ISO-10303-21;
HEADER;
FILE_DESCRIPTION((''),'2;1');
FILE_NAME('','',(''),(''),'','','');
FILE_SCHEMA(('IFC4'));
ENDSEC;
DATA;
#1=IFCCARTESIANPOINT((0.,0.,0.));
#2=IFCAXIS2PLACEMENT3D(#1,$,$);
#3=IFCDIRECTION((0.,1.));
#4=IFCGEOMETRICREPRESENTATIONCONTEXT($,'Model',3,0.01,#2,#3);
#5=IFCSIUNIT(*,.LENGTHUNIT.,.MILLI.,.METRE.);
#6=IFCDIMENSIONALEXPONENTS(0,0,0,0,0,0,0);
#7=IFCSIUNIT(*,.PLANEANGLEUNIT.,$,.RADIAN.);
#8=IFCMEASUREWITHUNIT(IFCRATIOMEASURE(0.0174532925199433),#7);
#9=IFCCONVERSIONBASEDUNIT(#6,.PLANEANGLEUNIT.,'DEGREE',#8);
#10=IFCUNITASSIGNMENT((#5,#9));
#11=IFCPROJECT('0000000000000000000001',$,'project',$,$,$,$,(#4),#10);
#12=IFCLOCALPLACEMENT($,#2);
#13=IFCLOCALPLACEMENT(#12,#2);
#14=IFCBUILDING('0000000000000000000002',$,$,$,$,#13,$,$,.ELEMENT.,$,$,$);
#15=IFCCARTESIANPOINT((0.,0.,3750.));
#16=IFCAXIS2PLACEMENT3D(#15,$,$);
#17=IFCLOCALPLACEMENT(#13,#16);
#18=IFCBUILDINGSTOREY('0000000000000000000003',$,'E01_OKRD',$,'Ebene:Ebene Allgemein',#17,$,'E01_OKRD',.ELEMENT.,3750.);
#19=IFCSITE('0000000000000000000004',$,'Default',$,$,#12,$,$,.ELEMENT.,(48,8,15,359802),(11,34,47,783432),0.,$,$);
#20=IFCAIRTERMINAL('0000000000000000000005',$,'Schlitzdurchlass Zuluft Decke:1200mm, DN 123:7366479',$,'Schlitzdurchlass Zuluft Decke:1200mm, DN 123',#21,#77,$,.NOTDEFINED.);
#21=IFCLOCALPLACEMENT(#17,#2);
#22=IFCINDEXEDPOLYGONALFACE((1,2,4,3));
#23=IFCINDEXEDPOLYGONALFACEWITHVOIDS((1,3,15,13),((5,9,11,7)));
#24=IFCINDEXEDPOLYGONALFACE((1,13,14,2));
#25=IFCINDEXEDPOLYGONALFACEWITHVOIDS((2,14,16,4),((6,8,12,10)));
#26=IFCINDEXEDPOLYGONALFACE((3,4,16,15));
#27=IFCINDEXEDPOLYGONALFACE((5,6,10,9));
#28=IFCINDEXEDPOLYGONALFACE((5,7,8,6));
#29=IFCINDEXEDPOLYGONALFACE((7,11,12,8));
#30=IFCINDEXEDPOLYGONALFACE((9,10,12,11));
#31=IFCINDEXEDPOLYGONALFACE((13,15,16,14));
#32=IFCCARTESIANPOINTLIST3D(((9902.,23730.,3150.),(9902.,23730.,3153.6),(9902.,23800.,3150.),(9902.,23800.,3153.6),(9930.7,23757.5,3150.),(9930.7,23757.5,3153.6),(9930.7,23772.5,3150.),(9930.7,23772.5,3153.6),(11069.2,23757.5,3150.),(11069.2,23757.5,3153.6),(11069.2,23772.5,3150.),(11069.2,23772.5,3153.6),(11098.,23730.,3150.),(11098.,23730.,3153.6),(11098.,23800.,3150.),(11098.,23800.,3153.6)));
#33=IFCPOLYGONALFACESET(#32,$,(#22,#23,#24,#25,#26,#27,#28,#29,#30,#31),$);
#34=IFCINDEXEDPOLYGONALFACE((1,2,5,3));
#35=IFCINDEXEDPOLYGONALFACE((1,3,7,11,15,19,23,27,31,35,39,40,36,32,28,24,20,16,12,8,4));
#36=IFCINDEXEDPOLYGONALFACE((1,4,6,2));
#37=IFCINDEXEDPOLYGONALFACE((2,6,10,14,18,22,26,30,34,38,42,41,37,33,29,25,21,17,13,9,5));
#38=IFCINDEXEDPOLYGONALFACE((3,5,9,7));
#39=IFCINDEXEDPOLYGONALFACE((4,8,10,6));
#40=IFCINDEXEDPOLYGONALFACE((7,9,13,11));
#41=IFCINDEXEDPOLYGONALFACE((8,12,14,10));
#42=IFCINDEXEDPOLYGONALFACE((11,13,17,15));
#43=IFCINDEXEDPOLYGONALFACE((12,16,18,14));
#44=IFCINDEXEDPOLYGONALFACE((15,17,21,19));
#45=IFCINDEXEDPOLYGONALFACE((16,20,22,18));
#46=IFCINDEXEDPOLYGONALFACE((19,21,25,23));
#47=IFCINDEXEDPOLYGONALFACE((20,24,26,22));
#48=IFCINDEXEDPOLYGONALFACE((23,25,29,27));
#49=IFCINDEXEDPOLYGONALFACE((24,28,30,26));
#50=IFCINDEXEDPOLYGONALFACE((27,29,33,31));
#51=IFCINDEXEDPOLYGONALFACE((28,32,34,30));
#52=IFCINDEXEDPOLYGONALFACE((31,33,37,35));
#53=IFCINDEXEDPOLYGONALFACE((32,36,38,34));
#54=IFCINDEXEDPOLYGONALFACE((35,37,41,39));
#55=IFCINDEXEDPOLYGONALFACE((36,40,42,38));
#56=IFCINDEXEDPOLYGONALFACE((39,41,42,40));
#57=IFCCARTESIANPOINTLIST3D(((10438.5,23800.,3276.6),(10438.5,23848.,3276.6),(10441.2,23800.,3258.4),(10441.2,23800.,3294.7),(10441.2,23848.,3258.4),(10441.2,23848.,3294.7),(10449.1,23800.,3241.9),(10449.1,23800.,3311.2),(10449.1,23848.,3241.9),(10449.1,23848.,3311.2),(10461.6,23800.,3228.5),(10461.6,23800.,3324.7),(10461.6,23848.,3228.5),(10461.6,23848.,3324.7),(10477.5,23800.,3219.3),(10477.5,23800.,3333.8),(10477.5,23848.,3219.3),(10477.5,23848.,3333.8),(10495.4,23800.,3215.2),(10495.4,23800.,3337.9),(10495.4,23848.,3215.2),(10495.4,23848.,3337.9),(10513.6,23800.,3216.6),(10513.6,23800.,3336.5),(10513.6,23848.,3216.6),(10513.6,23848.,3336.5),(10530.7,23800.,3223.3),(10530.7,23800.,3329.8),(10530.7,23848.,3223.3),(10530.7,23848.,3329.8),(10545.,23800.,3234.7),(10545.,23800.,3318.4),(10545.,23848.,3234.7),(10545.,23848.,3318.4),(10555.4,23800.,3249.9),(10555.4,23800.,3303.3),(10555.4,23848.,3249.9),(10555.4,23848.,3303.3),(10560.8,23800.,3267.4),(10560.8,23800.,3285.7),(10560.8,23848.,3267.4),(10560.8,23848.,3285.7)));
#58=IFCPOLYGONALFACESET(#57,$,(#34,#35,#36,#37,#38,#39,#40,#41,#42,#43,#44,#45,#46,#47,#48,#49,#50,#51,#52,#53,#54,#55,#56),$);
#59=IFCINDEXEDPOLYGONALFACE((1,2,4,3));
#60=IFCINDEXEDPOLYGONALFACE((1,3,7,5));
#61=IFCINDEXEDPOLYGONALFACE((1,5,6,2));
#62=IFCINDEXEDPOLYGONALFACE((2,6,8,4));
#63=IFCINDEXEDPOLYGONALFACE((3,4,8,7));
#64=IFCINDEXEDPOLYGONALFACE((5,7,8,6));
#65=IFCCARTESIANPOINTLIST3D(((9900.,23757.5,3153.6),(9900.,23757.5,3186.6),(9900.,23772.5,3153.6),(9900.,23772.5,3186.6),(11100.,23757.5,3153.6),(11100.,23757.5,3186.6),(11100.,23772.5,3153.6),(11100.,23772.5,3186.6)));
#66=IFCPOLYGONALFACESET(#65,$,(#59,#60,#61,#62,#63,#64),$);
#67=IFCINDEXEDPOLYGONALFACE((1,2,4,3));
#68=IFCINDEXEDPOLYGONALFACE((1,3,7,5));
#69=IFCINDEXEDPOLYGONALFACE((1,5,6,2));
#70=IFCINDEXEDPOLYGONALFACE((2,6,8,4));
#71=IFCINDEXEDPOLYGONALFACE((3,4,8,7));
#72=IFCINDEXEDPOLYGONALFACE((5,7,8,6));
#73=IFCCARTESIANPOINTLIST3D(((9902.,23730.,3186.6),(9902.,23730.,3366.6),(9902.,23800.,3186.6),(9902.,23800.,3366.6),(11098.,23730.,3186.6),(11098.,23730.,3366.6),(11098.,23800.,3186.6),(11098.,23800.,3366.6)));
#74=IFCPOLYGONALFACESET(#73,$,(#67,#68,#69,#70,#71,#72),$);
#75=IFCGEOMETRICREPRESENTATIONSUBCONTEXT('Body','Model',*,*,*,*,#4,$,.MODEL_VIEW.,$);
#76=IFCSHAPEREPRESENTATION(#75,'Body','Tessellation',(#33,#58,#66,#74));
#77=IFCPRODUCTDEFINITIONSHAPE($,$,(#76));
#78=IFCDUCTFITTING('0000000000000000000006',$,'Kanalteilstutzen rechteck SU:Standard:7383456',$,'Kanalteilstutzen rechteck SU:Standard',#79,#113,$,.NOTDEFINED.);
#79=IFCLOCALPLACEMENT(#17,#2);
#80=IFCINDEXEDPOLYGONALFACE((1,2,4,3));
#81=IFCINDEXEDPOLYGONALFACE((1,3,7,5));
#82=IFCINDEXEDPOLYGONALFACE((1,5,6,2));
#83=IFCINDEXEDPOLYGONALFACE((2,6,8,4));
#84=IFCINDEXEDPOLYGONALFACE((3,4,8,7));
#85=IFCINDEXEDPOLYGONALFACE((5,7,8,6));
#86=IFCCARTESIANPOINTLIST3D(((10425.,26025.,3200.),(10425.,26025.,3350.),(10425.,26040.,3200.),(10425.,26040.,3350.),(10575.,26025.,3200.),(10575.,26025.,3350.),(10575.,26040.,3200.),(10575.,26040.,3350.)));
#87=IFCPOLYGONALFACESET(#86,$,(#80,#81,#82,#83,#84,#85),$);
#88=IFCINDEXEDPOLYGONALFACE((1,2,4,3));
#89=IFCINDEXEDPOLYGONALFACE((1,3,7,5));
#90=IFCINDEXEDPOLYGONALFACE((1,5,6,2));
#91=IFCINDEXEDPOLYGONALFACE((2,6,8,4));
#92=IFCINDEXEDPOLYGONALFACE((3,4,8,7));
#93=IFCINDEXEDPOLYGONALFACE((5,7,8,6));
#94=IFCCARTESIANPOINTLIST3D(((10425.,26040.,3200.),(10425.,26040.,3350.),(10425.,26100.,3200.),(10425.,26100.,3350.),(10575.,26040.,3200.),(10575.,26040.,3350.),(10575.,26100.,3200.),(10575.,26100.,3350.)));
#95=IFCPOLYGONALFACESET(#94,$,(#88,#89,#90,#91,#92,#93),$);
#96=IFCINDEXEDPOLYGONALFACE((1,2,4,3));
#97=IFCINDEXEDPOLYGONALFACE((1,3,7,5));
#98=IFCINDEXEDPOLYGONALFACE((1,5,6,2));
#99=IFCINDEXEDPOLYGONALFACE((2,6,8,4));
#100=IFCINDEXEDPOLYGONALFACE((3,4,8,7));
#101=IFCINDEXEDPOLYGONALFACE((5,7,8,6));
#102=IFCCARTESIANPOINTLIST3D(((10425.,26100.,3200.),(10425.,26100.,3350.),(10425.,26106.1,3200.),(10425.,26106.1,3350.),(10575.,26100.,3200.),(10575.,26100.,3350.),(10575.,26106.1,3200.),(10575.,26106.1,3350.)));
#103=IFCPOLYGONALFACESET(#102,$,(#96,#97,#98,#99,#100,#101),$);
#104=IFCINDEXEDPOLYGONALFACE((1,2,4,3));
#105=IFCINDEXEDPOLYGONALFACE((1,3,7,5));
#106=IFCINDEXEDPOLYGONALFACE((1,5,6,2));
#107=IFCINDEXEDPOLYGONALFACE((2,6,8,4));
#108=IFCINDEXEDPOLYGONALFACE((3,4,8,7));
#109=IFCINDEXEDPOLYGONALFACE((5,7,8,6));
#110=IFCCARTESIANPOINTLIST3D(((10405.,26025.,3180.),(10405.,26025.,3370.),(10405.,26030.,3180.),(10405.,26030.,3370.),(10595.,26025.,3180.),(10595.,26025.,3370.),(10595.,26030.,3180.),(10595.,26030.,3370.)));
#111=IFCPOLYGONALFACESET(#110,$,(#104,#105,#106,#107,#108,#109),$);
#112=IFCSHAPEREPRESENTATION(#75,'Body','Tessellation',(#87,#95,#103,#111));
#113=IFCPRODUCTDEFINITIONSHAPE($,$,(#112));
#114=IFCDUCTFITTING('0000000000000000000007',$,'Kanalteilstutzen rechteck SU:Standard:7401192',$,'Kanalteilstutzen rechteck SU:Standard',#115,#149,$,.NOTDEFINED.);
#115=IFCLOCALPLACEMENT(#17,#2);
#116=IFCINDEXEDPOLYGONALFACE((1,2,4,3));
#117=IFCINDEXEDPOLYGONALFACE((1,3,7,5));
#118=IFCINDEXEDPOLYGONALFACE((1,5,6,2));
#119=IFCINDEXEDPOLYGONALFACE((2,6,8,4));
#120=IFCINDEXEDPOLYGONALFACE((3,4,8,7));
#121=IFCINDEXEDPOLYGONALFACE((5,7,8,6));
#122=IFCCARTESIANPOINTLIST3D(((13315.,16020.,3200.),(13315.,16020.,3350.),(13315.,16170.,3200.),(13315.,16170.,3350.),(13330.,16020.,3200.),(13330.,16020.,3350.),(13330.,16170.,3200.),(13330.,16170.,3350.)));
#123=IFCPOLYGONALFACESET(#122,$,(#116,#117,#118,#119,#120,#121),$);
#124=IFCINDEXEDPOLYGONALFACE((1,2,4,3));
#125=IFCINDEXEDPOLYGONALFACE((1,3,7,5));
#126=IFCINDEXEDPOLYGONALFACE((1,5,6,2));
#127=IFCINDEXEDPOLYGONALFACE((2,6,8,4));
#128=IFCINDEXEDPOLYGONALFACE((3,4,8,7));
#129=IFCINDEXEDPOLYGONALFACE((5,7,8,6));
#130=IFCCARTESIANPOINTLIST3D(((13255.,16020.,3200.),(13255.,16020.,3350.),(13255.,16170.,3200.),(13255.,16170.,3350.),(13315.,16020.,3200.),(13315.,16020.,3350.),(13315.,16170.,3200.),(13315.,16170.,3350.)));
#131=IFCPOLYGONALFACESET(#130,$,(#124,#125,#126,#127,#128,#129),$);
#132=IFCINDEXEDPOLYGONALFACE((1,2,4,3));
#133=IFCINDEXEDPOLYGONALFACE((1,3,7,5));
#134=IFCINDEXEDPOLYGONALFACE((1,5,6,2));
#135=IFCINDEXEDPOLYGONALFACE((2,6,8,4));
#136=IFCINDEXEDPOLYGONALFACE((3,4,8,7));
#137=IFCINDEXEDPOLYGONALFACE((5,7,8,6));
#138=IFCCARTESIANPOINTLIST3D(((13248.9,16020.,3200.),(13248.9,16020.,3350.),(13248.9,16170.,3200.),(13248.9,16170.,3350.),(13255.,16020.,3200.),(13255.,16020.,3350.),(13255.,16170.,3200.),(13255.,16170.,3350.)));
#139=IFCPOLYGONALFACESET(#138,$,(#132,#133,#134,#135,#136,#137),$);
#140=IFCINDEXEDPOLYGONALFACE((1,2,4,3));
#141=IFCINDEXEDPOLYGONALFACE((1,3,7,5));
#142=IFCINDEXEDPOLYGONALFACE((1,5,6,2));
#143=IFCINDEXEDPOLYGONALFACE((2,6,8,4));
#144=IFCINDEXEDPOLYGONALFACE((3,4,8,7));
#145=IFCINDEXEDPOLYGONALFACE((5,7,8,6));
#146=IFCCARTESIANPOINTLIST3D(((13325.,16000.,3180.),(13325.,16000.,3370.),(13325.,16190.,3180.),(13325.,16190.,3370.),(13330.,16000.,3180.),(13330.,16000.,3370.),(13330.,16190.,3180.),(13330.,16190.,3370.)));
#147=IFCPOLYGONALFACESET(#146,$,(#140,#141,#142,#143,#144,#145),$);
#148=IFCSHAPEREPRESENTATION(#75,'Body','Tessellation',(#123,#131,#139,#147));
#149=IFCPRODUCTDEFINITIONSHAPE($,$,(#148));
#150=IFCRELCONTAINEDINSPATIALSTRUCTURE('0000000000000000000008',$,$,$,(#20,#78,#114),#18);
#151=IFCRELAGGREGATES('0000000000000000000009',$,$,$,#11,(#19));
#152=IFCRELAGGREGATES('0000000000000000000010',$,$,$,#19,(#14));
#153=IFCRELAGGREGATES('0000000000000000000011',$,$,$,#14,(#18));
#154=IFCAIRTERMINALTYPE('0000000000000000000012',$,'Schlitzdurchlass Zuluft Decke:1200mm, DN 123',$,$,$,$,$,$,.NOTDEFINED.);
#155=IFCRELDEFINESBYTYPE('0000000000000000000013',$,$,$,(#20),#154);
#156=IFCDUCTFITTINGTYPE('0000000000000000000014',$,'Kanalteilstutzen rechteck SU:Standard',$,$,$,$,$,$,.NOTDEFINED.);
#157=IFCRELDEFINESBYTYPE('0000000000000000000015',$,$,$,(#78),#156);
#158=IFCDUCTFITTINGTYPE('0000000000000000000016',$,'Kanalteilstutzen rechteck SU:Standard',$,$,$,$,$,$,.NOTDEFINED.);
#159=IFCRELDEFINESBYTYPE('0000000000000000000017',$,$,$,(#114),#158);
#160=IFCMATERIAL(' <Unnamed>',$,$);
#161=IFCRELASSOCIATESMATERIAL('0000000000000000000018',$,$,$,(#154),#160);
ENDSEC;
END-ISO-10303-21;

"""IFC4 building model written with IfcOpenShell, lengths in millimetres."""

from ifc_helpers import new_model, entity, si_unit, converted_unit, direction, frame, frame_2d, origin, origin_2d_with_axis, place, context, subcontext, project, spatial, polyline, rectangle, circle, outline, extrude, source, transform, mapped, material, type_object, type_shapes, element, save


model = new_model("IFC4")

# Units and contexts
model_context = context("Model", 3, precision=0.01, world=origin(), true_north=direction((0.0, 1.0)))
body_context = subcontext(model_context, "Body", "Model", "MODEL_VIEW")
ifc_project = project(units=[si_unit("LENGTHUNIT", "METRE", prefix="MILLI"), converted_unit("PLANEANGLEUNIT", "DEGREE", entity("IfcRatioMeasure", 0.0174532925199433), si_unit("PLANEANGLEUNIT", "RADIAN"), dimensions=[0, 0, 0, 0, 0, 0, 0])], contexts=[model_context])

# Site, building, storey
site_placement = place(None, origin())
site = spatial("IfcSite", under=ifc_project, at=site_placement, Name="Default", CompositionType="ELEMENT", RefLatitude=(48, 8, 15, 359802), RefLongitude=(11, 34, 47, 783432), RefElevation=0.0)
building_placement = place(site_placement, origin())
building = spatial("IfcBuilding", under=site, at=building_placement, CompositionType="ELEMENT")
storey_placement = place(building_placement, frame((0.0, 0.0, 3750.0)))
storey = spatial("IfcBuildingStorey", under=building, at=storey_placement, Name="E01_OKRD", ObjectType="Ebene:Ebene Allgemein", LongName="E01_OKRD", CompositionType="ELEMENT", Elevation=3750.0)

# Air terminal
ifc_material_1 = material(Name=" <Unnamed>")
air_terminal_type_1 = type_object("IfcAirTerminalType", Name="Schlitzdurchlass Zuluft Decke:1200mm, DN 123", PredefinedType="NOTDEFINED", material=ifc_material_1)
shared_shape_1 = source(origin(), body_context, "Body", "SweptSolid", [
    extrude(outline(polyline([(-598.0, -35.0), (598.0, -35.0), (598.0, 35.0), (-598.0, 35.0), (-598.0, -35.0)]), holes=[polyline([(-569.2, -7.5), (-569.2, 7.5), (569.2, 7.5), (569.2, -7.5), (-569.2, -7.5)])]), frame((600.0, 35.0, 0.0), z_axis=(0.0, 0.0, 1.0), x_axis=(-1.0, 0.0, 0.0)), (0.0, 0.0, 1.0), 3.6),
    extrude(circle(Radius=61.5, at=frame_2d((0.0, 0.0), x_axis=(1.0, 0.0))), frame((600.0, 70.0, 126.6), z_axis=(0.0, 1.0, 0.0), x_axis=(-1.0, 0.0, 0.0)), (0.0, 0.0, 1.0), 48.0),
    extrude(rectangle(XDim=1200.0, YDim=15.0, at=origin_2d_with_axis()), frame((600.0, 35.0, 3.6), z_axis=(0.0, 0.0, 1.0), x_axis=(-1.0, 0.0, 0.0)), (0.0, 0.0, 1.0), 33.0),
    extrude(rectangle(XDim=1196.0, YDim=70.0, at=origin_2d_with_axis()), frame((600.0, 35.0, 36.6), z_axis=(0.0, 0.0, 1.0), x_axis=(-1.0, 0.0, 0.0)), (0.0, 0.0, 1.0), 180.0),
])
type_shapes(air_terminal_type_1, [shared_shape_1])
air_terminal_placement = place(storey_placement, frame((9900.0, 23730.0, 3150.0)))
element("IfcAirTerminal", 1, at=air_terminal_placement, inside=storey, type_object=air_terminal_type_1, Name="Schlitzdurchlass Zuluft Decke:1200mm, DN 123:7366479", ObjectType="Schlitzdurchlass Zuluft Decke:1200mm, DN 123", PredefinedType="NOTDEFINED", context=body_context, shape_type="MappedRepresentation", body=[
    mapped(shared_shape_1, transform((0.0, 0.0, 0.0), scale=1.0)),
])

# Duct fittings
duct_fitting_type_1 = type_object("IfcDuctFittingType", Name="Kanalteilstutzen rechteck SU:Standard", PredefinedType="NOTDEFINED")
shared_shape_2 = source(origin(), body_context, "Body", "SweptSolid", [
    extrude(rectangle(XDim=150.0, YDim=15.0, at=origin_2d_with_axis()), frame((67.5, 0.0, -75.0), z_axis=(0.0, 0.0, 1.0), x_axis=(0.0, -1.0, 0.0)), (0.0, 0.0, 1.0), 150.0),
    extrude(rectangle(XDim=150.0, YDim=60.0, at=frame_2d((0.0, 0.0), x_axis=(1.0, 0.0))), frame((30.0, 0.0, -75.0), z_axis=(0.0, 0.0, 1.0), x_axis=(0.0, -1.0, 0.0)), (0.0, 0.0, 1.0), 150.0),
    extrude(rectangle(XDim=150.0, YDim=6.1, at=frame_2d((0.0, 0.0), x_axis=(1.0, 0.0))), frame((-3.0, 0.0, -75.0), z_axis=(0.0, 0.0, 1.0), x_axis=(0.0, -1.0, 0.0)), (0.0, 0.0, 1.0), 150.0),
    extrude(rectangle(XDim=190.0, YDim=5.0, at=origin_2d_with_axis()), frame((72.5, 0.0, -95.0), z_axis=(0.0, 0.0, 1.0), x_axis=(0.0, -1.0, 0.0)), (0.0, 0.0, 1.0), 190.0),
])
type_shapes(duct_fitting_type_1, [shared_shape_2])
duct_fitting_1_placement = place(storey_placement, frame((10500.0, 26100.0, 3275.0), z_axis=(0.0, 0.0, -1.0), x_axis=(0.0, -1.0, 0.0)))
element("IfcDuctFitting", 2, at=duct_fitting_1_placement, inside=storey, type_object=duct_fitting_type_1, Name="Kanalteilstutzen rechteck SU:Standard:7383456", ObjectType="Kanalteilstutzen rechteck SU:Standard", PredefinedType="NOTDEFINED", context=body_context, shape_type="MappedRepresentation", body=[
    mapped(shared_shape_2, transform((0.0, 0.0, 0.0), scale=1.0)),
])
duct_fitting_type_2 = type_object("IfcDuctFittingType", Name="Kanalteilstutzen rechteck SU:Standard", PredefinedType="NOTDEFINED")
shared_shape_3 = source(origin(), body_context, "Body", "SweptSolid", [
    extrude(rectangle(XDim=15.0, YDim=150.0, at=frame_2d((0.0, 0.0), x_axis=(1.0, 0.0))), frame((67.5, 0.0, -75.0)), (0.0, 0.0, 1.0), 150.0),
    extrude(rectangle(XDim=60.0, YDim=150.0, at=frame_2d((0.0, 0.0), x_axis=(1.0, 0.0))), frame((30.0, 0.0, -75.0)), (0.0, 0.0, 1.0), 150.0),
    extrude(rectangle(XDim=6.1, YDim=150.0, at=frame_2d((0.0, 0.0), x_axis=(1.0, 0.0))), frame((-3.0, 0.0, -75.0)), (0.0, 0.0, 1.0), 150.0),
    extrude(rectangle(XDim=5.0, YDim=190.0, at=origin_2d_with_axis()), frame((72.5, 0.0, -95.0)), (0.0, 0.0, 1.0), 190.0),
])
type_shapes(duct_fitting_type_2, [shared_shape_3])
duct_fitting_2_placement = place(storey_placement, frame((13255.0, 16095.0, 3275.0), z_axis=(0.0, 0.0, -1.0), x_axis=(1.0, 0.0, 0.0)))
element("IfcDuctFitting", 3, at=duct_fitting_2_placement, inside=storey, type_object=duct_fitting_type_2, Name="Kanalteilstutzen rechteck SU:Standard:7401192", ObjectType="Kanalteilstutzen rechteck SU:Standard", PredefinedType="NOTDEFINED", context=body_context, shape_type="MappedRepresentation", body=[
    mapped(shared_shape_3, transform((0.0, 0.0, 0.0), scale=1.0)),
])

save(model, "model.ifc")
